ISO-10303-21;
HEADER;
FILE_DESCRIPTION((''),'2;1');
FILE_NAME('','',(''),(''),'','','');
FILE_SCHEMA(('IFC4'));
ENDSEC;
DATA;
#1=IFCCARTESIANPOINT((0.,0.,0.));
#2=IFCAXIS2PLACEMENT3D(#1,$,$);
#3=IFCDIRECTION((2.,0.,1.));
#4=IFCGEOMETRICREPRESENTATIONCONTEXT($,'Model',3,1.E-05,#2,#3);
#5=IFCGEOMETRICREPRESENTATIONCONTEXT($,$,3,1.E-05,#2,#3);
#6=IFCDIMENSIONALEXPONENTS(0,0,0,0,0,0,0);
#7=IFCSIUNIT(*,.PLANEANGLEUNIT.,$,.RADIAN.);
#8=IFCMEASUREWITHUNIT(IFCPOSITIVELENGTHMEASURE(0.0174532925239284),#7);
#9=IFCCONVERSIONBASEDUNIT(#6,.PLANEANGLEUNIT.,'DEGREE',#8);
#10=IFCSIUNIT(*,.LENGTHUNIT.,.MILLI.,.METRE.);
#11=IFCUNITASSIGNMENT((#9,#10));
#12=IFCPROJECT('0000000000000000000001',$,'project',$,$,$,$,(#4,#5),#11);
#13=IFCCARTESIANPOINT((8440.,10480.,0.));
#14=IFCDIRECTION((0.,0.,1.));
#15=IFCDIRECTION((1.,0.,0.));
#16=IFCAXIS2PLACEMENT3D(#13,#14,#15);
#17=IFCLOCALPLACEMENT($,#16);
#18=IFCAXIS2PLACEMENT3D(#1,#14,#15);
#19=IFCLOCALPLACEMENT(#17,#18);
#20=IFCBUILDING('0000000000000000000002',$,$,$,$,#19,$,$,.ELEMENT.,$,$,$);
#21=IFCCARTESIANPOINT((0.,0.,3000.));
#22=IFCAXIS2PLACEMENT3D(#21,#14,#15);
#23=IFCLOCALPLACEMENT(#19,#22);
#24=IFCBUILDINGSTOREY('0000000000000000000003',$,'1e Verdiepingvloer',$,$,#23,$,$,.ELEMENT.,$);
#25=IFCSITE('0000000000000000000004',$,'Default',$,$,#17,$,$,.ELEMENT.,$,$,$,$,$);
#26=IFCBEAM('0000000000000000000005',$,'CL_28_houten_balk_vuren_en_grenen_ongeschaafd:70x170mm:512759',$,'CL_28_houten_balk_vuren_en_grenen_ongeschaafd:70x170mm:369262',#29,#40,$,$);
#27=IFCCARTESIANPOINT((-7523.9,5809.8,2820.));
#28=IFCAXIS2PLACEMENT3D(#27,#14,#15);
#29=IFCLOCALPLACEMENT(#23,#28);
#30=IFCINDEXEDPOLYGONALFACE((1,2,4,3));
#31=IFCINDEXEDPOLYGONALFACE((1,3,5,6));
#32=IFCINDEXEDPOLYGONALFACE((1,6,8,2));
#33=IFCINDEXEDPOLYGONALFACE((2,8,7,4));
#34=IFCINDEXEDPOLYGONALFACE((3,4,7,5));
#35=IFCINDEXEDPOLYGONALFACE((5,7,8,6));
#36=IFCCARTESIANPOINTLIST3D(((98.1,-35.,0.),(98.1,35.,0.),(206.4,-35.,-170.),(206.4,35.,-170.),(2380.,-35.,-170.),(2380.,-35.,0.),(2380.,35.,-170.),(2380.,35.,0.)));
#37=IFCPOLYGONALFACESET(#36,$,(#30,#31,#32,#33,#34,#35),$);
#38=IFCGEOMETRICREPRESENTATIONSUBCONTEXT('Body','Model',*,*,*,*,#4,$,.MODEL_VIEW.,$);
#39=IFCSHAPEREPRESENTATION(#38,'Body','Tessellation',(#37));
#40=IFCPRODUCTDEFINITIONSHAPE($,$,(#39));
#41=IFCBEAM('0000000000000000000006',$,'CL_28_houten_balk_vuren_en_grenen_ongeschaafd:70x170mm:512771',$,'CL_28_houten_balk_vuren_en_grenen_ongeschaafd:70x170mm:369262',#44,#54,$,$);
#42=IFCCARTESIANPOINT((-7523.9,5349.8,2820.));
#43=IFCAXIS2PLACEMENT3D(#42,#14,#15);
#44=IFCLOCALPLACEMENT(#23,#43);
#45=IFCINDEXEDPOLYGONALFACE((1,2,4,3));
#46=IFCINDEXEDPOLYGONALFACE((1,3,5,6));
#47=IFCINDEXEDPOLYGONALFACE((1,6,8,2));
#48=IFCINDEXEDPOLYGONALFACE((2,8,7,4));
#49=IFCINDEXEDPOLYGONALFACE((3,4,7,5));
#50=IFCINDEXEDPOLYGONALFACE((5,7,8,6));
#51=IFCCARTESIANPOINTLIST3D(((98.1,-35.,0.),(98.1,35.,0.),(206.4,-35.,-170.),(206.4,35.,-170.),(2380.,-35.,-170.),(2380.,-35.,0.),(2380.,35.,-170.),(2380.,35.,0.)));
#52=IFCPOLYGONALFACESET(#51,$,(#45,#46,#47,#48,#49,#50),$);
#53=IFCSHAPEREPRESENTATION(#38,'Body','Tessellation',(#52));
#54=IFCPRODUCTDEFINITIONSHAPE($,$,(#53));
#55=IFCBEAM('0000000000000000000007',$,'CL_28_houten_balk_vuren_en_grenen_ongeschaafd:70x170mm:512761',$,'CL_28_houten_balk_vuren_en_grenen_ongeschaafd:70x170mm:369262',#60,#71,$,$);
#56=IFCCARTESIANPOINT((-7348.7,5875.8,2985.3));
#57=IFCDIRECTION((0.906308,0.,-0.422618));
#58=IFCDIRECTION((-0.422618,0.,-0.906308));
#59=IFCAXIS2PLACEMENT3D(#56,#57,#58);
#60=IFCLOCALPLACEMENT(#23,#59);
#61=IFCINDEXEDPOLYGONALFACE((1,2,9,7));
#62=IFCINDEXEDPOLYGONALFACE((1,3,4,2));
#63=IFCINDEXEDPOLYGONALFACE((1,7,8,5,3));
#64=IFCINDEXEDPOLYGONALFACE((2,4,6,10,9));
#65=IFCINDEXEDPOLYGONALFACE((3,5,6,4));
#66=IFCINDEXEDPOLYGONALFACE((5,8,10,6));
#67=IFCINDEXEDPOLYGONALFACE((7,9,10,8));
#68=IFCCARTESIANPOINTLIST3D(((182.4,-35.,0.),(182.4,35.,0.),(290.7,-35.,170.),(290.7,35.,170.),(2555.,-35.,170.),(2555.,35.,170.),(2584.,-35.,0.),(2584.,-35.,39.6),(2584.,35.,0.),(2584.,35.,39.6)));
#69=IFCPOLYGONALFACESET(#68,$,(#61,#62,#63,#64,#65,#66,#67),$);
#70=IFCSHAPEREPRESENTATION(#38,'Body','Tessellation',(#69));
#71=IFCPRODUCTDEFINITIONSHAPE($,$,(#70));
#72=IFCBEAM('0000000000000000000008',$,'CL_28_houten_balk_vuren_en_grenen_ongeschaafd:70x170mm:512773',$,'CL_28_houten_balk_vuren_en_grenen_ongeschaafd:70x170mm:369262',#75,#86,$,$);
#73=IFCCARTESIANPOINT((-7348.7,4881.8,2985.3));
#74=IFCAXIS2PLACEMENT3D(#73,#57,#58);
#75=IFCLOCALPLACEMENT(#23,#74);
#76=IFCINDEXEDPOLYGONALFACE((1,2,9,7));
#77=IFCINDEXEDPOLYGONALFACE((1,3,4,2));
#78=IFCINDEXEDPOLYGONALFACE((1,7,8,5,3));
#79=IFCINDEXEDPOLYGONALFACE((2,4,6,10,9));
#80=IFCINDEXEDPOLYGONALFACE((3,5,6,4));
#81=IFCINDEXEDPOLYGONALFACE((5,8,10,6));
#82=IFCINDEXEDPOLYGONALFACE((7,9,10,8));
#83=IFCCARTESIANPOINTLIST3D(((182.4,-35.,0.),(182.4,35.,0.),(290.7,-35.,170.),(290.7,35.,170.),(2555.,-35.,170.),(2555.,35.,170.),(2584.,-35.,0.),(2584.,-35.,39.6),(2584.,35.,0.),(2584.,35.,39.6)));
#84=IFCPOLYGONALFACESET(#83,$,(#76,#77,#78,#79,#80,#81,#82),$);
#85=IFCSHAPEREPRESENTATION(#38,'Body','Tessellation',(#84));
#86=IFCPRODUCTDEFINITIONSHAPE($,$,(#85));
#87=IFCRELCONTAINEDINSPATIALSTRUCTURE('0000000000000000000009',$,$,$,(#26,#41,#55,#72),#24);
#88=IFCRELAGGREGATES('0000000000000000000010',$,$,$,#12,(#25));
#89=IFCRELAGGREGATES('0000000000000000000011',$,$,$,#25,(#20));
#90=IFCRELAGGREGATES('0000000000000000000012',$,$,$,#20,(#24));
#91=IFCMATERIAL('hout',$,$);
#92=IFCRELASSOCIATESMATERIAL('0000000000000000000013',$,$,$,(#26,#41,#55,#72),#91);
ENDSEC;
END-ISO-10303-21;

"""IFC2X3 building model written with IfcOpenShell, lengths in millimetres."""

from ifc_helpers import new_model, entity, si_unit, converted_unit, direction, frame, frame_2d, origin, origin_with_axes, place, context, subcontext, project, spatial, rectangle, extrude, clip, halfspace, source, transform, mapped, material, element, save


model = new_model("IFC2X3")

# Units and contexts
model_context = context("Model", 3, precision=1e-05, world=origin(), true_north=direction((2.0, 0.0, 1.0)))
context_of_model = context(None, 3, precision=1e-05, world=origin(), true_north=direction((2.0, 0.0, 1.0)))
body_context = subcontext(model_context, "Body", "Model", "MODEL_VIEW")
ifc_project = project(units=[converted_unit("PLANEANGLEUNIT", "DEGREE", entity("IfcPositiveLengthMeasure", 0.0174532925239284), si_unit("PLANEANGLEUNIT", "RADIAN"), dimensions=[0, 0, 0, 0, 0, 0, 0]), si_unit("LENGTHUNIT", "METRE", prefix="MILLI")], contexts=[model_context, context_of_model])

# Site, building, storey
site_placement = place(None, frame((8440.0, 10480.0, 0.0), z_axis=(0.0, 0.0, 1.0), x_axis=(1.0, 0.0, 0.0)))
site = spatial("IfcSite", under=ifc_project, at=site_placement, Name="Default", CompositionType="ELEMENT")
building_placement = place(site_placement, origin_with_axes())
building = spatial("IfcBuilding", under=site, at=building_placement, CompositionType="ELEMENT")
storey_placement = place(building_placement, frame((0.0, 0.0, 3000.0), z_axis=(0.0, 0.0, 1.0), x_axis=(1.0, 0.0, 0.0)))
storey = spatial("IfcBuildingStorey", under=building, at=storey_placement, Name="1e Verdiepingvloer", CompositionType="ELEMENT")

# Beams
ifc_material_1 = material(Name="hout")
shared_shape_1 = source(origin(), body_context, "Body", "Clipping", [
    clip(extrude(rectangle(XDim=170.0, YDim=70.0, at=frame_2d((0.0, 0.0), x_axis=(1.0, 0.0))), frame((98.1, 0.0, -85.0), z_axis=(1.0, 0.0, 0.0), x_axis=(0.0, 0.0, -1.0)), (0.0, 0.0, 1.0), 2281.9), halfspace(frame((206.4, -683.2, -170.0), z_axis=(-0.843391, 0.0, -0.5373), x_axis=(0.5373, 0.0, -0.843391)), False)),
])
for number, where, z_axis, x_axis, name in (
    (1, (-7523.9, 5809.8, 2820.0), (0.0, 0.0, 1.0), (1.0, 0.0, 0.0), "CL_28_houten_balk_vuren_en_grenen_ongeschaafd:70x170mm:512759"),
    (2, (-7523.9, 5349.8, 2820.0), (0.0, 0.0, 1.0), (1.0, 0.0, 0.0), "CL_28_houten_balk_vuren_en_grenen_ongeschaafd:70x170mm:512771"),
):
    element("IfcBeam", number, at=place(storey_placement, frame(where, z_axis=z_axis, x_axis=x_axis)), inside=storey, material=ifc_material_1, Name=name, ObjectType="CL_28_houten_balk_vuren_en_grenen_ongeschaafd:70x170mm:369262", context=body_context, shape_type="MappedRepresentation", body=[
        mapped(shared_shape_1, transform((0.0, 0.0, 0.0))),
    ])
shared_shape_2 = source(origin(), body_context, "Body", "Clipping", [
    clip(clip(extrude(rectangle(XDim=170.0, YDim=70.0, at=frame_2d((0.0, 0.0), x_axis=(0.0, 1.0))), frame((182.4, 0.0, 85.0), z_axis=(1.0, 0.0, 0.0), x_axis=(0.0, 1.0, 0.0)), (0.0, 0.0, 1.0), 2401.5), halfspace(frame((2590.9, -1982.2, 8.5), z_axis=(0.976296, 0.0, 0.21644), x_axis=(-0.21644, 0.0, 0.976296)), False)), halfspace(frame((290.7, -683.2, 170.0), z_axis=(-0.843391, 0.0, 0.5373), x_axis=(0.5373, 0.0, 0.843391)), False)),
])
for number, where, z_axis, x_axis, name in (
    (3, (-7348.7, 5875.8, 2985.3), (0.906308, 0.0, -0.422618), (-0.422618, 0.0, -0.906308), "CL_28_houten_balk_vuren_en_grenen_ongeschaafd:70x170mm:512761"),
    (4, (-7348.7, 4881.8, 2985.3), (0.906308, 0.0, -0.422618), (-0.422618, 0.0, -0.906308), "CL_28_houten_balk_vuren_en_grenen_ongeschaafd:70x170mm:512773"),
):
    element("IfcBeam", number, at=place(storey_placement, frame(where, z_axis=z_axis, x_axis=x_axis)), inside=storey, material=ifc_material_1, Name=name, ObjectType="CL_28_houten_balk_vuren_en_grenen_ongeschaafd:70x170mm:369262", context=body_context, shape_type="MappedRepresentation", body=[
        mapped(shared_shape_2, transform((0.0, 0.0, 0.0))),
    ])

save(model, "model.ifc")
